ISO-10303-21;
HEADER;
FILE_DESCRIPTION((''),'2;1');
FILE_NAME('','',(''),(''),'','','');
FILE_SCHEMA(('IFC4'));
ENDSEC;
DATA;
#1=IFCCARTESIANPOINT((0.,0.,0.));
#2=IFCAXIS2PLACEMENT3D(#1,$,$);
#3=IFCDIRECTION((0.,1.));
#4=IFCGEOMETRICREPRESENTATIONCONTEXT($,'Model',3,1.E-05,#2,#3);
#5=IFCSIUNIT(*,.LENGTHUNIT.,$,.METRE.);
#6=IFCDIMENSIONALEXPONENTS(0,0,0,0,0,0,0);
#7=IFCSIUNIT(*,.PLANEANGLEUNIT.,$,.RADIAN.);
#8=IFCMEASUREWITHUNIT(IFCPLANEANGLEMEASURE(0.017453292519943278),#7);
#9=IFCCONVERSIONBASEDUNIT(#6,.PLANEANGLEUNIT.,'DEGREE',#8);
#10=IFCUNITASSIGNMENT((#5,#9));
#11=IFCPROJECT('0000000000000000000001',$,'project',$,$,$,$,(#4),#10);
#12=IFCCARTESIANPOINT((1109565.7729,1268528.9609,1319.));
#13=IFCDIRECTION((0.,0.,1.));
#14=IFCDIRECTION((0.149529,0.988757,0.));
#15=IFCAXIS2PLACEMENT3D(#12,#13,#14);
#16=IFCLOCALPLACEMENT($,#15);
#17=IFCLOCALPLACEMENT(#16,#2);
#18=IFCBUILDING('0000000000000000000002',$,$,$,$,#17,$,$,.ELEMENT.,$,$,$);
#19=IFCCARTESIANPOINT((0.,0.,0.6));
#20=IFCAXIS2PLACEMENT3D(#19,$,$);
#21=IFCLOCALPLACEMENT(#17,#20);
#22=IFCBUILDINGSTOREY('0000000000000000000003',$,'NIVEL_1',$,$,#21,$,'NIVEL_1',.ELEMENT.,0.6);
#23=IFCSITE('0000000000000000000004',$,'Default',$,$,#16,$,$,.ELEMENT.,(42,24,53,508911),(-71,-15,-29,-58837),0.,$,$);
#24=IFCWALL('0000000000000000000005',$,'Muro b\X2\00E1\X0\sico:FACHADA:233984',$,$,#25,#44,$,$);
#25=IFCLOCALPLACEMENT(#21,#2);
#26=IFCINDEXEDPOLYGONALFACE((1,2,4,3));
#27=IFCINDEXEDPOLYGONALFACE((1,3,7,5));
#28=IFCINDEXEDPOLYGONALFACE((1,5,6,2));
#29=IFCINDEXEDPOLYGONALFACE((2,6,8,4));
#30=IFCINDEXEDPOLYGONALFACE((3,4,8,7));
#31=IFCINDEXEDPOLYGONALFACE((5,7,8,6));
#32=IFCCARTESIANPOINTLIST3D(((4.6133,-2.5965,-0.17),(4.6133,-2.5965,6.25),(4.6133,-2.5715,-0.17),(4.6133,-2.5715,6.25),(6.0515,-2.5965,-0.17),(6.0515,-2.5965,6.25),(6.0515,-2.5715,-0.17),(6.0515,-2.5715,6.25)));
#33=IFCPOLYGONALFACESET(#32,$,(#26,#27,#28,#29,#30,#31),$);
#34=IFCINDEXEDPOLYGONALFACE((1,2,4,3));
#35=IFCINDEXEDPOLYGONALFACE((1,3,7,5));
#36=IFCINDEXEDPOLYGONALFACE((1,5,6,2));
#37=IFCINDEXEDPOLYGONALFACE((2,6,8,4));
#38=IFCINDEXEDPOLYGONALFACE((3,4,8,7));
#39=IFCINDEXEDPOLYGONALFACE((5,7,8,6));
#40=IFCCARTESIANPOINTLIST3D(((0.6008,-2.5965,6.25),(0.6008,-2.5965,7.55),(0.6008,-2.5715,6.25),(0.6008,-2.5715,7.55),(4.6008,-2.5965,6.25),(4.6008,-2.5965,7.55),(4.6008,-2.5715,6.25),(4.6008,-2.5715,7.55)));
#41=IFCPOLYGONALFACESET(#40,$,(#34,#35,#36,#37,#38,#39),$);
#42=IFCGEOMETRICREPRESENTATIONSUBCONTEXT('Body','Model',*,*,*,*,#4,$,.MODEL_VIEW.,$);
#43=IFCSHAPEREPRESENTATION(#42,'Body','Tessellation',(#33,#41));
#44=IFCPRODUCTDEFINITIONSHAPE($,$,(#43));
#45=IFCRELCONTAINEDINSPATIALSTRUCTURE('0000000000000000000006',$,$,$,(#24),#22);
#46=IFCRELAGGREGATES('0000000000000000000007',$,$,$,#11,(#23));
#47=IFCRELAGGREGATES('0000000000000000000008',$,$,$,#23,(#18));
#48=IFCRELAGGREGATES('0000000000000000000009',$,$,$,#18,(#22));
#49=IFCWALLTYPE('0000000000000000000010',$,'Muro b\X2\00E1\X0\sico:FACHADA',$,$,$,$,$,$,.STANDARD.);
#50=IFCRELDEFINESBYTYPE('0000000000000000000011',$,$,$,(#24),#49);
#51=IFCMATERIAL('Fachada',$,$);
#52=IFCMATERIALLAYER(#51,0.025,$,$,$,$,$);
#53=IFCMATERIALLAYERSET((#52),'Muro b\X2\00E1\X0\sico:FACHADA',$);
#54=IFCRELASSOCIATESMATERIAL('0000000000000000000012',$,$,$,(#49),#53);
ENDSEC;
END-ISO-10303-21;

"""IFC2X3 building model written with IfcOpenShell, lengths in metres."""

from ifc_helpers import new_model, entity, si_unit, converted_unit, direction, frame, frame_2d, origin, place, context, subcontext, project, spatial, rectangle, extrude, material, layer, layer_set, type_object, element, save


model = new_model("IFC2X3")

# Units and contexts
model_context = context("Model", 3, precision=1e-05, world=origin(), true_north=direction((0.0, 1.0)))
body_context = subcontext(model_context, "Body", "Model", "MODEL_VIEW")
ifc_project = project(units=[si_unit("LENGTHUNIT", "METRE"), converted_unit("PLANEANGLEUNIT", "DEGREE", entity("IfcPlaneAngleMeasure", 0.017453292519943278), si_unit("PLANEANGLEUNIT", "RADIAN"), dimensions=[0, 0, 0, 0, 0, 0, 0])], contexts=[model_context])

# Site, building, storey
site_placement = place(None, frame((1109565.7729, 1268528.9609, 1319.0), z_axis=(0.0, 0.0, 1.0), x_axis=(0.149529, 0.988757, 0.0)))
site = spatial("IfcSite", under=ifc_project, at=site_placement, Name="Default", CompositionType="ELEMENT", RefLatitude=(42, 24, 53, 508911), RefLongitude=(-71, -15, -29, -58837), RefElevation=0.0)
building_placement = place(site_placement, origin())
building = spatial("IfcBuilding", under=site, at=building_placement, CompositionType="ELEMENT")
storey_placement = place(building_placement, frame((0.0, 0.0, 0.6)))
storey = spatial("IfcBuildingStorey", under=building, at=storey_placement, Name="NIVEL_1", LongName="NIVEL_1", CompositionType="ELEMENT", Elevation=0.6)

# Shared definitions
ifc_material_1 = material(Name="Fachada")
ifc_layer_1 = layer(ifc_material_1, 0.025)
ifc_layer_set_1 = layer_set([ifc_layer_1], Name="Muro básico:FACHADA")
wall_type_1 = type_object("IfcWallType", Name="Muro básico:FACHADA", PredefinedType="STANDARD", material=ifc_layer_set_1)

# Wall
wall_1_placement = place(storey_placement, frame((6.0515, -2.584, -0.17), z_axis=(0.0, 0.0, 1.0), x_axis=(-1.0, 0.0, 0.0)))
element("IfcWall", 1, at=wall_1_placement, inside=storey, type_object=wall_type_1, Name="Muro básico:FACHADA:233984", context=body_context, shape_type="SweptSolid", body=[
    extrude(rectangle(XDim=0.025, YDim=1.4382, at=frame_2d((0.0, 0.0), x_axis=(1.0, 0.0))), frame((0.7191, 0.0, 0.0), z_axis=(0.0, 0.0, 1.0), x_axis=(0.0, 1.0, 0.0)), (0.0, 0.0, 1.0), 6.42),
    extrude(rectangle(XDim=0.025, YDim=4.0, at=frame_2d((0.0, 0.0), x_axis=(1.0, 0.0))), frame((3.4507, 0.0, 6.42), z_axis=(0.0, 0.0, 1.0), x_axis=(0.0, 1.0, 0.0)), (0.0, 0.0, 1.0), 1.3),
])

save(model, "model.ifc")
